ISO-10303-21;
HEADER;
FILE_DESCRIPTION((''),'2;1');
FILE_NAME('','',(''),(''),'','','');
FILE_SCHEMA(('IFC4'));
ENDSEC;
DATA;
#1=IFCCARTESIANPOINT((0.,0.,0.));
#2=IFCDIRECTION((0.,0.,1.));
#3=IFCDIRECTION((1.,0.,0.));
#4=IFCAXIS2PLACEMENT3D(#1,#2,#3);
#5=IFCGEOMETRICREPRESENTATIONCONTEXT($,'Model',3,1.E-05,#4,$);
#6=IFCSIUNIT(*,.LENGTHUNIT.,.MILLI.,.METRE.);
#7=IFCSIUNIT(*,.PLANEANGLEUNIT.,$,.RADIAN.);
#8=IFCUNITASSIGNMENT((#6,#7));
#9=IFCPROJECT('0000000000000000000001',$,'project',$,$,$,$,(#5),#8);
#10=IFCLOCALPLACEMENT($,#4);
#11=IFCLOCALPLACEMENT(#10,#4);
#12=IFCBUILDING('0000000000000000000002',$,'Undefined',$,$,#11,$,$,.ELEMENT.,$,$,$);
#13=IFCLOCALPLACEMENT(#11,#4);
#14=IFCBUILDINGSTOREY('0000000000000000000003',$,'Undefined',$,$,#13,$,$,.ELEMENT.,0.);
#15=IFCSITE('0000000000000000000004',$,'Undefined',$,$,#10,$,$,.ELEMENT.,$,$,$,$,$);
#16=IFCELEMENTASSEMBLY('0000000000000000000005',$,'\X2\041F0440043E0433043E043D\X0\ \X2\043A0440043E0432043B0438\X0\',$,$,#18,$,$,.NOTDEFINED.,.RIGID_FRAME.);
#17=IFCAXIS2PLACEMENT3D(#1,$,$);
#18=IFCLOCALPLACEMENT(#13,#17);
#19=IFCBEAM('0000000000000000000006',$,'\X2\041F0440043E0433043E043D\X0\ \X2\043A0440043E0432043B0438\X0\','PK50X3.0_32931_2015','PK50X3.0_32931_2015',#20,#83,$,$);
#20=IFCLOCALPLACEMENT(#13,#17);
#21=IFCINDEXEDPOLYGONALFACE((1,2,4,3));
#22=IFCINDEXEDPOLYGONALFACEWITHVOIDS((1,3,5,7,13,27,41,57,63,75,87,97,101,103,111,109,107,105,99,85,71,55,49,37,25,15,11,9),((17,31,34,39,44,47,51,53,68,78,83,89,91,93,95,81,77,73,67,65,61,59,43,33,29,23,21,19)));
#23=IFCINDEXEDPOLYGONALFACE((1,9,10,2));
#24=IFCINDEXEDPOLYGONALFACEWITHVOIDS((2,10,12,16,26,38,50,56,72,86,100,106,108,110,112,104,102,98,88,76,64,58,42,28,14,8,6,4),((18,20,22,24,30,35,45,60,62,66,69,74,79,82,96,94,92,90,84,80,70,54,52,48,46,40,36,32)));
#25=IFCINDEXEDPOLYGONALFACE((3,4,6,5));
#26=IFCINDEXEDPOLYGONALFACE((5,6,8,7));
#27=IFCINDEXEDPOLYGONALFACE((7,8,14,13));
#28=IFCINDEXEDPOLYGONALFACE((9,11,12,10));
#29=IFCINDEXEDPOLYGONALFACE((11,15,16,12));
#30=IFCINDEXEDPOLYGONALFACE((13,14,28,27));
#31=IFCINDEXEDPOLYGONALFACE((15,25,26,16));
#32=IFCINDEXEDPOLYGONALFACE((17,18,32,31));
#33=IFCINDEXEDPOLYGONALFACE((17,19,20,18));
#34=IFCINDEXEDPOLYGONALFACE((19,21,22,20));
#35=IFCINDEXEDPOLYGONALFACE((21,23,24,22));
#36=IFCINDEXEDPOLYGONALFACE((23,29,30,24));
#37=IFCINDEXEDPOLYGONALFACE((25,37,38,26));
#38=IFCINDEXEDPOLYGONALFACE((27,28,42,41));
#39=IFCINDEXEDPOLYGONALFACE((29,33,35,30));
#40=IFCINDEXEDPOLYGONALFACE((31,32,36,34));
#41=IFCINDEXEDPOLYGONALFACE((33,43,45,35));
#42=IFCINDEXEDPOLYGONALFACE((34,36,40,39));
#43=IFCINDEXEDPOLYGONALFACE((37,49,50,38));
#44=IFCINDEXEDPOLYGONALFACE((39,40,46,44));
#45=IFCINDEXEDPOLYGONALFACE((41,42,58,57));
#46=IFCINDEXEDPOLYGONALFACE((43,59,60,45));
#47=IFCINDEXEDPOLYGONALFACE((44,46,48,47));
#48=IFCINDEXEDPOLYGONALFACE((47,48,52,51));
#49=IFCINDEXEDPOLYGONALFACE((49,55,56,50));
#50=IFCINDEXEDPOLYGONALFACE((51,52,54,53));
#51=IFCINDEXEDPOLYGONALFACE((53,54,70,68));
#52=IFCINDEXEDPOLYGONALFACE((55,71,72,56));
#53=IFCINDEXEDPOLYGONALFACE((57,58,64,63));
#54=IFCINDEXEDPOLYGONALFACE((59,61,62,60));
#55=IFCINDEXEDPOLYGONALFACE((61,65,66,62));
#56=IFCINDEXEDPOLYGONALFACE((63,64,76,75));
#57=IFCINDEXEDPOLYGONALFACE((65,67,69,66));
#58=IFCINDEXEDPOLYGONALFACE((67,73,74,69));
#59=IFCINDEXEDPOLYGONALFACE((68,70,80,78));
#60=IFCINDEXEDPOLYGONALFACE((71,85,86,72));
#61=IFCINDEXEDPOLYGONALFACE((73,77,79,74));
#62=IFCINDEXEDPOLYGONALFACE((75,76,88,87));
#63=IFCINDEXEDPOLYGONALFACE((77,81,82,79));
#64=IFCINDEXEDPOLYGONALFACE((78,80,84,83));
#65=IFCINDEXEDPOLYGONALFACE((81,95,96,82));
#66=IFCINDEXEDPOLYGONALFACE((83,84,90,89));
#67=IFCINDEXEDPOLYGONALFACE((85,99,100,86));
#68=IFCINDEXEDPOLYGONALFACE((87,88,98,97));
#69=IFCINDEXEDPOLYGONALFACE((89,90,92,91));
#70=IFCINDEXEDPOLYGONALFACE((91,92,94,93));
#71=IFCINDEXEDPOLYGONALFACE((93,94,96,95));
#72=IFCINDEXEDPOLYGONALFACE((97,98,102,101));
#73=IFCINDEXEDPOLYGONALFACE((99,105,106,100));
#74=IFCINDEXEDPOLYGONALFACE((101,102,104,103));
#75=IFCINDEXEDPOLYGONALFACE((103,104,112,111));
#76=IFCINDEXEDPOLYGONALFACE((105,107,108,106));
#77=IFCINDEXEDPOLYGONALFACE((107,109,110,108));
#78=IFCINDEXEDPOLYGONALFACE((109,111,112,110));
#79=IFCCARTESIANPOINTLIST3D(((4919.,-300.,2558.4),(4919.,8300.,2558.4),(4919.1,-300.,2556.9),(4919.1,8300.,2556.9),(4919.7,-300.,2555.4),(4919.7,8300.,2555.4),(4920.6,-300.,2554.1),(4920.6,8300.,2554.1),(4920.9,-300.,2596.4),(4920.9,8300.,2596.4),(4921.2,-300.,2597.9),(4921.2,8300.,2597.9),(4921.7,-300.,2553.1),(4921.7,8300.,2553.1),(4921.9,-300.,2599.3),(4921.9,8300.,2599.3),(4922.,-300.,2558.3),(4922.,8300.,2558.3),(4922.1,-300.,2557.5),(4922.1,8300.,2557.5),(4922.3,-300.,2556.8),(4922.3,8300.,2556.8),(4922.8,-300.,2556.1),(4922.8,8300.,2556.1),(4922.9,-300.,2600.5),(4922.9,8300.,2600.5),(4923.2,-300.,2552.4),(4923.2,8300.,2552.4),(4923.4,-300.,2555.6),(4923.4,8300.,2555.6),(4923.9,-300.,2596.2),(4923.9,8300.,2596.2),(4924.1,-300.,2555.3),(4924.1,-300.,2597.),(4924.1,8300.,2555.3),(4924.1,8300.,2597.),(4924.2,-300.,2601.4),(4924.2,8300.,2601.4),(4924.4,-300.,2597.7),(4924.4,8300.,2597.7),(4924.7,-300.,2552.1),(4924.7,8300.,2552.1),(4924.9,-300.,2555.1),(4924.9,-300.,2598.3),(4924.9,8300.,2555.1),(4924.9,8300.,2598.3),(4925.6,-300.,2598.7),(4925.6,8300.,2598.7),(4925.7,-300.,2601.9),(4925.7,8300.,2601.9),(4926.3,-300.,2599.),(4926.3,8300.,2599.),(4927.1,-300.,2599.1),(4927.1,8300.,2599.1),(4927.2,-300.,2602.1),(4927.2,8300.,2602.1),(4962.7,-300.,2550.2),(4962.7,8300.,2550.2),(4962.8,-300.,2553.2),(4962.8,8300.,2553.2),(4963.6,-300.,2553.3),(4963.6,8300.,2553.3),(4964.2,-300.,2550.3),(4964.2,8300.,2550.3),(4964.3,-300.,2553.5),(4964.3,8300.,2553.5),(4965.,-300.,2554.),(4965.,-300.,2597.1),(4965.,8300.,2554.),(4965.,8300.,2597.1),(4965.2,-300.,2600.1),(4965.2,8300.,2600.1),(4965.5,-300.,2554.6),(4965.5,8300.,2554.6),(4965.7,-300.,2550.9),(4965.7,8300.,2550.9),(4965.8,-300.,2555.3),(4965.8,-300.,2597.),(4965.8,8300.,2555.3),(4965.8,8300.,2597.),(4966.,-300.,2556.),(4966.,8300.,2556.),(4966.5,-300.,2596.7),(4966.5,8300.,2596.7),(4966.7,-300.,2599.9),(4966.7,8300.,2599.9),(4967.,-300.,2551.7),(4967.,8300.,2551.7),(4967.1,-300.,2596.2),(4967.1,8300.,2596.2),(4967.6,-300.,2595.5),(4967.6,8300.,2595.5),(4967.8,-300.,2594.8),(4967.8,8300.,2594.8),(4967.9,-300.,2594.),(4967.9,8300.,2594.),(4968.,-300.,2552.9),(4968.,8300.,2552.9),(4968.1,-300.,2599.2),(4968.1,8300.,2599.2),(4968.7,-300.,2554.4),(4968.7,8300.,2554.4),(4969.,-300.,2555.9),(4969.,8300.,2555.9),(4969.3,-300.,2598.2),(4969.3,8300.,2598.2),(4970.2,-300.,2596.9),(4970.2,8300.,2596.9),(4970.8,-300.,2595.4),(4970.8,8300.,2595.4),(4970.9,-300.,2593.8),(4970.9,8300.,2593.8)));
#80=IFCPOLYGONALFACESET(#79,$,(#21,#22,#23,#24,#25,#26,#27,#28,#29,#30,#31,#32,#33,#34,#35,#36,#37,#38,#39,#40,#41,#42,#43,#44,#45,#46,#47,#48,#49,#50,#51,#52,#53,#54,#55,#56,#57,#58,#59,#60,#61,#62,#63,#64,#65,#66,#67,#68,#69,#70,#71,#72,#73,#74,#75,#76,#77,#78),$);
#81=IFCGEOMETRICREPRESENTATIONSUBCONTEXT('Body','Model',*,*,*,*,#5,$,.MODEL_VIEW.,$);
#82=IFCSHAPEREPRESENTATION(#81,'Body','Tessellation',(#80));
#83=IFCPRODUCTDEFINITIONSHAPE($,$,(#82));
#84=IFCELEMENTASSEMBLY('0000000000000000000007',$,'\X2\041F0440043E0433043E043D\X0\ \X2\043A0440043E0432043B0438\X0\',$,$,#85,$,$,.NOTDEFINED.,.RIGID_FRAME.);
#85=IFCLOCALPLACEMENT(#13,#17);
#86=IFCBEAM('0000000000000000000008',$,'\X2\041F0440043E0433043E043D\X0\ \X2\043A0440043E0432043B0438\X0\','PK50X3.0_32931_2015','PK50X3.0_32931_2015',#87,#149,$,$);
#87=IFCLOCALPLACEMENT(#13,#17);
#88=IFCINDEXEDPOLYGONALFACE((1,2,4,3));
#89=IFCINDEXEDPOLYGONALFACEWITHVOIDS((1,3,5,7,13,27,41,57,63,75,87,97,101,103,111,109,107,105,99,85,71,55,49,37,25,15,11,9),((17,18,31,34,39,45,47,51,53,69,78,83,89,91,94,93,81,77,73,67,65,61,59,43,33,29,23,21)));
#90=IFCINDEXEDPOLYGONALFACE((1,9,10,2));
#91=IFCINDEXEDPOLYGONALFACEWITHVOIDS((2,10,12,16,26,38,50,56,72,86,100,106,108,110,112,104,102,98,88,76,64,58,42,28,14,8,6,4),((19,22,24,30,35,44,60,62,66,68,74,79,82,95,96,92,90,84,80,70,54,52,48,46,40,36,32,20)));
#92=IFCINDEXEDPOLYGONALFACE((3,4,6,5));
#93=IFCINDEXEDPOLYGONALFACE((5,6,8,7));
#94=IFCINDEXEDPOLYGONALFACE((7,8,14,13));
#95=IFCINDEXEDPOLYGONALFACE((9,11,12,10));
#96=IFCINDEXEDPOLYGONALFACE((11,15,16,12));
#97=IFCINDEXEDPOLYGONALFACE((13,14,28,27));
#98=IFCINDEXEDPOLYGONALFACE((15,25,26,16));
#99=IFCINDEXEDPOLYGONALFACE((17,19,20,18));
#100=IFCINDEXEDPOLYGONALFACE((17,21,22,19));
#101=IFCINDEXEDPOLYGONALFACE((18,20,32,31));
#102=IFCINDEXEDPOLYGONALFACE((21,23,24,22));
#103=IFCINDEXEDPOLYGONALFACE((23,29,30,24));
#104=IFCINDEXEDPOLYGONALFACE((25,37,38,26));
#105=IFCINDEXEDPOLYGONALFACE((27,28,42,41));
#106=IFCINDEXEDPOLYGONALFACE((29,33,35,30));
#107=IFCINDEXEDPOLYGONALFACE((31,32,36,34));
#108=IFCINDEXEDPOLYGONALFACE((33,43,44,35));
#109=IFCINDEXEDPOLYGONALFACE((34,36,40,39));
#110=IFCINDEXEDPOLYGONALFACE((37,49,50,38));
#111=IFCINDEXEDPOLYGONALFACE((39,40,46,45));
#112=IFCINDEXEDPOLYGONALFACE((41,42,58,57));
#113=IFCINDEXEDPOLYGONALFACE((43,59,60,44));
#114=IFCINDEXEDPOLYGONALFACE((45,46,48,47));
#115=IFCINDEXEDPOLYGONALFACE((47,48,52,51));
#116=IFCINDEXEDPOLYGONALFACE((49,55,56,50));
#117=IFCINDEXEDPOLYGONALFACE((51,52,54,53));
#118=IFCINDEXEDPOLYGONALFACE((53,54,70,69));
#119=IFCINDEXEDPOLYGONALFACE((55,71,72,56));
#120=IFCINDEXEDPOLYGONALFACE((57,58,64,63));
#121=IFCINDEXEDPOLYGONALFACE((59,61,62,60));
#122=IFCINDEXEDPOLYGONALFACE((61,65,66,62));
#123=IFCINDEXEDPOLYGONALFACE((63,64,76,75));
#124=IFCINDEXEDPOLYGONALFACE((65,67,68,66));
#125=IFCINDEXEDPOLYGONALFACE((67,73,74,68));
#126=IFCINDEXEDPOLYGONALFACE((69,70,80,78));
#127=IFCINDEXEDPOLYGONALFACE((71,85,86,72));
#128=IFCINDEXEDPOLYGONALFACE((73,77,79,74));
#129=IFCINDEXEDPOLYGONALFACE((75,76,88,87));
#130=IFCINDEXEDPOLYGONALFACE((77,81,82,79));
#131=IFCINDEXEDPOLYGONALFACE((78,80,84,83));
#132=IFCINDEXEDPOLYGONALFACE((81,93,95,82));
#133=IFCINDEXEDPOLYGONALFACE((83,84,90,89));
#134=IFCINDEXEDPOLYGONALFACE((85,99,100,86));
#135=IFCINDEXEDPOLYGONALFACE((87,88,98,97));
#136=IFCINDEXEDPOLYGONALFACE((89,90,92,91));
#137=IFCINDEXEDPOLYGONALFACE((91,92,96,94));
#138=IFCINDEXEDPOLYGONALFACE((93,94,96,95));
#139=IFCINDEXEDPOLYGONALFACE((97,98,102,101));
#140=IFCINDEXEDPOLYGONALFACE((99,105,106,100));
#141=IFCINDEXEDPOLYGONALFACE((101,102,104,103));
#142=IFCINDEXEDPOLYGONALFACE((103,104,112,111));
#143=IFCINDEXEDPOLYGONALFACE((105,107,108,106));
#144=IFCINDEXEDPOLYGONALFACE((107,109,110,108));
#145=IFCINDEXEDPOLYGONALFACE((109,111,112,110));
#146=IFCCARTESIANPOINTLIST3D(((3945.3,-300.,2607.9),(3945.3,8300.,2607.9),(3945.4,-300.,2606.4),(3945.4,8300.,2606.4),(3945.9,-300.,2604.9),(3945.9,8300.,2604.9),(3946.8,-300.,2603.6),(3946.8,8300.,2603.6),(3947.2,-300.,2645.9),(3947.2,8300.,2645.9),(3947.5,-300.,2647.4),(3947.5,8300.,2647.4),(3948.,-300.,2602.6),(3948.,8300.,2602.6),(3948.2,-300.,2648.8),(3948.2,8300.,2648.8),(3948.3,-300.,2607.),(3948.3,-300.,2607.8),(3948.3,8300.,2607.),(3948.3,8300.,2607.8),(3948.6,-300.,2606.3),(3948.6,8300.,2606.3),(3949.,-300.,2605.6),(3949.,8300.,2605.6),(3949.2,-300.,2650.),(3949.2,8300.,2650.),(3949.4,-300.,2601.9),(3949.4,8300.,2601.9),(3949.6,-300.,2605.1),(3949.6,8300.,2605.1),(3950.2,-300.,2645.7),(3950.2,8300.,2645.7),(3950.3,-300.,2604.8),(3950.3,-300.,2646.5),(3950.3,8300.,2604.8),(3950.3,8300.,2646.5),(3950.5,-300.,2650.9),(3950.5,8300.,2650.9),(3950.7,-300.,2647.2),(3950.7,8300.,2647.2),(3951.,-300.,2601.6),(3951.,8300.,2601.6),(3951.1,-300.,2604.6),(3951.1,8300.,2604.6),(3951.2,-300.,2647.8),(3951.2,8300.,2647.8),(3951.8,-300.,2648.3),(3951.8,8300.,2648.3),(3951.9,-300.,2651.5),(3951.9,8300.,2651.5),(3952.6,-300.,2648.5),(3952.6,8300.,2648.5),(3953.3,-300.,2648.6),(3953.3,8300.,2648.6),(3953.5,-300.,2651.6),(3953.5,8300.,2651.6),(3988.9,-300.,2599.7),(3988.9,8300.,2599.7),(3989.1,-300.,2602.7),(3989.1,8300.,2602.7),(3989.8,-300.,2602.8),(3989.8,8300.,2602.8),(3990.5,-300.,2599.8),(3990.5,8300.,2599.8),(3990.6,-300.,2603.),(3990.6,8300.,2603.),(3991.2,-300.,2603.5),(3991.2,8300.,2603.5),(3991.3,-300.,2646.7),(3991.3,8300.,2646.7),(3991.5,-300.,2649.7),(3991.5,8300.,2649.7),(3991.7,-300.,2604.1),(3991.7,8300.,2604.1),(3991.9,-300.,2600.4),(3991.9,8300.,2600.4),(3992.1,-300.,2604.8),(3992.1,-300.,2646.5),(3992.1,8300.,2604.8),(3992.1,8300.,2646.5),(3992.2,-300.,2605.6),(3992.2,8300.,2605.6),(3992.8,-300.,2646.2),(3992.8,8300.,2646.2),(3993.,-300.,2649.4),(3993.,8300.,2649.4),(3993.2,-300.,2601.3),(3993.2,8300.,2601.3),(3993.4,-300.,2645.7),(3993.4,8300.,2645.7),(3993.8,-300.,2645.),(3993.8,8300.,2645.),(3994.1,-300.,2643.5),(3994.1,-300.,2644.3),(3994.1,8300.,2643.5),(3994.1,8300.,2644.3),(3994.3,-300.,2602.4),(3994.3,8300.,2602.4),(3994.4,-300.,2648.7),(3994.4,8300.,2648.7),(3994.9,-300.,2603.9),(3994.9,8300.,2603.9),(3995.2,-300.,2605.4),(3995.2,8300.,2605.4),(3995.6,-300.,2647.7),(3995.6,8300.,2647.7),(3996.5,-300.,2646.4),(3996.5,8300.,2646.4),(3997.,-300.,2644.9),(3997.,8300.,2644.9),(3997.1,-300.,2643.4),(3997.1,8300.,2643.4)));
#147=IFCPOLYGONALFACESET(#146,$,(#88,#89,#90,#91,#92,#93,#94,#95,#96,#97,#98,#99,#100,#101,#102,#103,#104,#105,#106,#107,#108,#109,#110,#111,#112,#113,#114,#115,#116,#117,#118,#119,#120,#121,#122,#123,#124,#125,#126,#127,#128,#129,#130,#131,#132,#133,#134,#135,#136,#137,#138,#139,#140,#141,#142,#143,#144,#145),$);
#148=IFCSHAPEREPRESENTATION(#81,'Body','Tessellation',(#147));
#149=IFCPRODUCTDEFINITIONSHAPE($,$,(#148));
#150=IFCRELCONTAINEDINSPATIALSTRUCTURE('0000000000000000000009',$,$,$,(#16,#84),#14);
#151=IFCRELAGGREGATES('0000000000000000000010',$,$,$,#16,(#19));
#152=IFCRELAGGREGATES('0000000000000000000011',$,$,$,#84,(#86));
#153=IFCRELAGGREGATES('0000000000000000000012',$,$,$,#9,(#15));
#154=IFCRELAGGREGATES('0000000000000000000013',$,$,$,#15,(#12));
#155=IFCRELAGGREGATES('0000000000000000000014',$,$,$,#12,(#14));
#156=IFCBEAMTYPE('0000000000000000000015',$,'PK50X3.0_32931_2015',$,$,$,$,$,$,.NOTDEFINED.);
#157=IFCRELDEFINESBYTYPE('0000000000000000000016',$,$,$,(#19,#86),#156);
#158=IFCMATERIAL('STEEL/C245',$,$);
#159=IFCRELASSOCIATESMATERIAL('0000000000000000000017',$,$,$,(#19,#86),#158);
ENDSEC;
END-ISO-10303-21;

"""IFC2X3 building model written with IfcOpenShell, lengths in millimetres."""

from ifc_helpers import new_model, si_unit, frame, origin_with_axes, origin_2d_with_axis, place, context, subcontext, project, spatial, hollow_rectangle, extrude, material, type_object, element, aggregate, save


model = new_model("IFC2X3")

# Units and contexts
model_context = context("Model", 3, precision=1e-05, world=origin_with_axes())
body_context = subcontext(model_context, "Body", "Model", "MODEL_VIEW")
ifc_project = project(units=[si_unit("LENGTHUNIT", "METRE", prefix="MILLI"), si_unit("PLANEANGLEUNIT", "RADIAN")], contexts=[model_context])

# Site, building, storey
site_placement = place(None, origin_with_axes())
site = spatial("IfcSite", under=ifc_project, at=site_placement, Name="Undefined", CompositionType="ELEMENT")
building_placement = place(site_placement, origin_with_axes())
building = spatial("IfcBuilding", under=site, at=building_placement, Name="Undefined", CompositionType="ELEMENT")
storey_placement = place(building_placement, origin_with_axes())
storey = spatial("IfcBuildingStorey", under=building, at=storey_placement, Name="Undefined", CompositionType="ELEMENT", Elevation=0.0)

# Shared definitions
ifc_material_1 = material(Name="STEEL/C245")

# Element assemblies, beams
beam_type_1 = type_object("IfcBeamType", Name="PK50X3.0_32931_2015", PredefinedType="NOTDEFINED")
assembly_1_placement = place(storey_placement, origin_with_axes())
assembly_1 = element("IfcElementAssembly", 1, at=assembly_1_placement, inside=storey, Name="Прогон кровли", AssemblyPlace="NOTDEFINED", PredefinedType="RIGID_FRAME")
beam_1_placement = place(assembly_1_placement, frame((4944.9, -300.0, 2576.1), z_axis=(0.050782, 0.0, 0.99871), x_axis=(0.0, 1.0, 0.0)))
beam_1 = element("IfcBeam", 2, at=beam_1_placement, type_object=beam_type_1, material=ifc_material_1, Name="Прогон кровли", Description="PK50X3.0_32931_2015", ObjectType="PK50X3.0_32931_2015", context=body_context, shape_type="SweptSolid", body=[
    extrude(hollow_rectangle(XDim=50.0, YDim=50.0, WallThickness=3.0, InnerFilletRadius=3.0, OuterFilletRadius=6.0, at=origin_2d_with_axis()), frame((8600.0, 0.0, 0.0), z_axis=(-1.0, 0.0, 0.0), x_axis=(0.0, -1.0, 0.0)), (0.0, 0.0, 1.0), 8600.0),
])
aggregate(assembly_1, [beam_1])
assembly_2_placement = place(storey_placement, origin_with_axes())
assembly_2 = element("IfcElementAssembly", 3, at=assembly_2_placement, inside=storey, Name="Прогон кровли", AssemblyPlace="NOTDEFINED", PredefinedType="RIGID_FRAME")
beam_2_placement = place(assembly_2_placement, frame((3971.2, -300.0, 2625.6), z_axis=(0.050782, 0.0, 0.99871), x_axis=(0.0, 1.0, 0.0)))
beam_2 = element("IfcBeam", 4, at=beam_2_placement, type_object=beam_type_1, material=ifc_material_1, Name="Прогон кровли", Description="PK50X3.0_32931_2015", ObjectType="PK50X3.0_32931_2015", context=body_context, shape_type="SweptSolid", body=[
    extrude(hollow_rectangle(XDim=50.0, YDim=50.0, WallThickness=3.0, InnerFilletRadius=3.0, OuterFilletRadius=6.0, at=origin_2d_with_axis()), frame((8600.0, 0.0, 0.0), z_axis=(-1.0, 0.0, 0.0), x_axis=(0.0, -1.0, 0.0)), (0.0, 0.0, 1.0), 8600.0),
])
aggregate(assembly_2, [beam_2])

save(model, "model.ifc")
